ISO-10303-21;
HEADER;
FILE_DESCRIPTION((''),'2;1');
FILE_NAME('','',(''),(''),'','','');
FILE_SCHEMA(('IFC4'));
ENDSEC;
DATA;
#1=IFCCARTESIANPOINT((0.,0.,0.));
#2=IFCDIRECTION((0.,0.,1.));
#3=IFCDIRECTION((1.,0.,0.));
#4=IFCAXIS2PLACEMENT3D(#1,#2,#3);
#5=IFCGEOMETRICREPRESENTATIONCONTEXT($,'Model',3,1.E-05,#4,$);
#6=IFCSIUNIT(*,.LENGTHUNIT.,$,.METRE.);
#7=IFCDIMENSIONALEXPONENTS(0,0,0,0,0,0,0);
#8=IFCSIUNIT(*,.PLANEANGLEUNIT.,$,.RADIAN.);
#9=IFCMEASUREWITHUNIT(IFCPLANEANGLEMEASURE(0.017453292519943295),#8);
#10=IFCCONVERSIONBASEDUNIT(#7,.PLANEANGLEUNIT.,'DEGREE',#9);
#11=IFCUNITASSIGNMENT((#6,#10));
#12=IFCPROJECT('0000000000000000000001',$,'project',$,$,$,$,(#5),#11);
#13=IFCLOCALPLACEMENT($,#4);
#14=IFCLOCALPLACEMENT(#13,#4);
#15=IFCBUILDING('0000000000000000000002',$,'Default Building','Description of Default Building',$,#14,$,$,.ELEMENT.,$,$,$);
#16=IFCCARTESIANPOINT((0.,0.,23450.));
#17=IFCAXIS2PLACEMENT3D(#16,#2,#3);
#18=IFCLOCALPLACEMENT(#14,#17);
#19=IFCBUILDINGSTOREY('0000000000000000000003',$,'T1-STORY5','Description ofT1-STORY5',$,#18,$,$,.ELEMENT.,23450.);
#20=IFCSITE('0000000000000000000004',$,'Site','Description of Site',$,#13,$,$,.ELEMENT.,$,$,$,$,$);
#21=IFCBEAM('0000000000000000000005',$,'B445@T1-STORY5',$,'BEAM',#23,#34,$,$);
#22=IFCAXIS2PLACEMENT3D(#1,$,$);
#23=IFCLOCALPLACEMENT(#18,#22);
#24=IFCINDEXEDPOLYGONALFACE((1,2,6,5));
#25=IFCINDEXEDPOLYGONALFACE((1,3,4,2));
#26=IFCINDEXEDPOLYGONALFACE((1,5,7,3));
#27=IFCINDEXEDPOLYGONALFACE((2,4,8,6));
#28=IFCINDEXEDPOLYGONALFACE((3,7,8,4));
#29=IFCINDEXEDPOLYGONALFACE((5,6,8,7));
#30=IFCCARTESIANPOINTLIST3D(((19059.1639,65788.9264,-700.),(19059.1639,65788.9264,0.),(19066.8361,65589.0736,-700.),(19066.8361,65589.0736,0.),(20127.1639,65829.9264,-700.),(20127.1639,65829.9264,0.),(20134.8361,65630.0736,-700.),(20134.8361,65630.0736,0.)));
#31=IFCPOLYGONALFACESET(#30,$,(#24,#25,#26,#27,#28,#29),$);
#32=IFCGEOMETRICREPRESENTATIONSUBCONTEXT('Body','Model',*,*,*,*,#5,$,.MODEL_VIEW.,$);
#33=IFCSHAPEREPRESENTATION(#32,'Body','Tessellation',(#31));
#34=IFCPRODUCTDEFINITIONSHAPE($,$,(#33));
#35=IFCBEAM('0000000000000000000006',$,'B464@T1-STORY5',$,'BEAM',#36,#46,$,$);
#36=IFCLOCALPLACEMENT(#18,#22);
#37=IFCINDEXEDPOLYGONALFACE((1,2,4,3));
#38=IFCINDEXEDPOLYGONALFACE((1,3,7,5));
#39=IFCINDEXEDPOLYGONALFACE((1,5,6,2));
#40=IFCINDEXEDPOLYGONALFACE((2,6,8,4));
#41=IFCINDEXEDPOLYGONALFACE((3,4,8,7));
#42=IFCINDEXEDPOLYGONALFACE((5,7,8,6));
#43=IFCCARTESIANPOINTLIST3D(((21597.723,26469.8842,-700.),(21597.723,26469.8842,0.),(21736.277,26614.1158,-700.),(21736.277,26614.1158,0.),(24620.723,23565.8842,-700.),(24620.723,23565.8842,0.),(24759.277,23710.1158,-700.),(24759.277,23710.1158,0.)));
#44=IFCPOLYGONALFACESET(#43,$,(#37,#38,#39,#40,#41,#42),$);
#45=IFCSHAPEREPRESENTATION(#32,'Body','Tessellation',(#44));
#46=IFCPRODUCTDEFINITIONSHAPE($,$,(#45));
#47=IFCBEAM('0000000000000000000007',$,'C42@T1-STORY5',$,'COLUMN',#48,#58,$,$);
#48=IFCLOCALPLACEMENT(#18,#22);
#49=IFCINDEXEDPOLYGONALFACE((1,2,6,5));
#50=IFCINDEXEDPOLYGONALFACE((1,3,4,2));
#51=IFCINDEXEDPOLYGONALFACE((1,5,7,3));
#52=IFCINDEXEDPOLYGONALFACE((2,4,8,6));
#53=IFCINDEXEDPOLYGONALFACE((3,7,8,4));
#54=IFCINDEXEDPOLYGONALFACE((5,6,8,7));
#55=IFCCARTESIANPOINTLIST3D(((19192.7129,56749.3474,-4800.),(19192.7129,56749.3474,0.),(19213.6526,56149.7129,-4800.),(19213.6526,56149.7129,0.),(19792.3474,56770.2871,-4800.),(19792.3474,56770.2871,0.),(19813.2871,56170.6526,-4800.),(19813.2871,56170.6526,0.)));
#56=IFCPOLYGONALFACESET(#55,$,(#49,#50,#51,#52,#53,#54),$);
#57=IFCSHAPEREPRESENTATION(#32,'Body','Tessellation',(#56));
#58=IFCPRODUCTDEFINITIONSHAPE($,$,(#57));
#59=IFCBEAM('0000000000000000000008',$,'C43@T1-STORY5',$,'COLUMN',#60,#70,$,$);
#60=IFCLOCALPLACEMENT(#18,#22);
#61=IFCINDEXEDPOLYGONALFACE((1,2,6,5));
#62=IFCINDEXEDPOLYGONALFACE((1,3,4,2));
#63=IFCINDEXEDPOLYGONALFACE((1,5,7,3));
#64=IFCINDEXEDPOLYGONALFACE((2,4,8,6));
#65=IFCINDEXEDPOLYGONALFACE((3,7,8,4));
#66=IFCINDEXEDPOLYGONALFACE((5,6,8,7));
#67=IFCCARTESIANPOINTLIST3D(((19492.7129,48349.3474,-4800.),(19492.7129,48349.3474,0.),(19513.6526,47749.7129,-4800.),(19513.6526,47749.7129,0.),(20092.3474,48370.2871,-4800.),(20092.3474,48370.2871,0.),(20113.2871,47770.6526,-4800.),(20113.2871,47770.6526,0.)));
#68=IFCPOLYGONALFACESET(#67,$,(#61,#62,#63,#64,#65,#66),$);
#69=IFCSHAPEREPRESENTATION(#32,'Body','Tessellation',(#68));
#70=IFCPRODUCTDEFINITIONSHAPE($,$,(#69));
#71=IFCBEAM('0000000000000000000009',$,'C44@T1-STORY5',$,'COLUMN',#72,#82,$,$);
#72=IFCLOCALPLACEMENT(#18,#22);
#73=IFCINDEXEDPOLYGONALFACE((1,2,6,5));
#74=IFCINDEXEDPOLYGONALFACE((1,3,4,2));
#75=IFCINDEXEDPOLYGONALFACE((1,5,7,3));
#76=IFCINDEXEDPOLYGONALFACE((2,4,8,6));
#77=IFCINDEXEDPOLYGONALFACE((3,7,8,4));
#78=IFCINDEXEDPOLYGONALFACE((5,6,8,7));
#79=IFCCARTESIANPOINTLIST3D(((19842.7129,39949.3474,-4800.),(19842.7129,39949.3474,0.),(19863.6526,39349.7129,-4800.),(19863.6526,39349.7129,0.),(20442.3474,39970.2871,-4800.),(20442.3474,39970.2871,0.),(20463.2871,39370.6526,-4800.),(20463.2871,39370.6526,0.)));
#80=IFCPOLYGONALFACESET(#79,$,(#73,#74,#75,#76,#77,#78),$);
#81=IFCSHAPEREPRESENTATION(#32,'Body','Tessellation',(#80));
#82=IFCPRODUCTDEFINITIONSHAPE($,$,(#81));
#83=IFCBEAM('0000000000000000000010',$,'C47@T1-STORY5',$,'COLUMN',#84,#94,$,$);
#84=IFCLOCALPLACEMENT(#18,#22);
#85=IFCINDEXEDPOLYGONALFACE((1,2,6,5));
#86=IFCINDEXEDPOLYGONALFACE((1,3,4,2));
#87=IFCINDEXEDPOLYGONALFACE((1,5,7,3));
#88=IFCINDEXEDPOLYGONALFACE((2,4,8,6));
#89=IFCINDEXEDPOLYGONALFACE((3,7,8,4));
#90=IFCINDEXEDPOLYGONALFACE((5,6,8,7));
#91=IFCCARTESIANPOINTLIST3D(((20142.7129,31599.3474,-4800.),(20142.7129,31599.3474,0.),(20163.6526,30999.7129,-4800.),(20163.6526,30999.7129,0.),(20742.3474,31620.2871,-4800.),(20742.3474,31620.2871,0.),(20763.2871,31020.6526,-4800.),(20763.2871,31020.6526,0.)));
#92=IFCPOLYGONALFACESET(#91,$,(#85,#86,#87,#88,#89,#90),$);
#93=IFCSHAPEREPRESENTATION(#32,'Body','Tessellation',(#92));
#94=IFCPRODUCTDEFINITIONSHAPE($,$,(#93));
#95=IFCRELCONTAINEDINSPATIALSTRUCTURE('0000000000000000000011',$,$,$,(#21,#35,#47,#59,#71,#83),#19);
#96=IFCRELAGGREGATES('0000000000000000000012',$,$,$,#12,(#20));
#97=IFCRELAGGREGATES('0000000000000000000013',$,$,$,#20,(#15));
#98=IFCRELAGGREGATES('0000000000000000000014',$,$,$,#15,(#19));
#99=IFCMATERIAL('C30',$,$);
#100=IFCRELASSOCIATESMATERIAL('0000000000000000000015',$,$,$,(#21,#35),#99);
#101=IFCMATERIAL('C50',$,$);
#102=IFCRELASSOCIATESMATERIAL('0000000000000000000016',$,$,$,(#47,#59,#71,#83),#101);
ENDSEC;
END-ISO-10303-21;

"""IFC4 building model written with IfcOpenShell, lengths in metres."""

from ifc_helpers import new_model, entity, si_unit, converted_unit, frame, origin_with_axes, place, context, subcontext, project, spatial, rectangle, extrude, material, element, save


model = new_model("IFC4")

# Units and contexts
model_context = context("Model", 3, precision=1e-05, world=origin_with_axes())
body_context = subcontext(model_context, "Body", "Model", "MODEL_VIEW")
ifc_project = project(units=[si_unit("LENGTHUNIT", "METRE"), converted_unit("PLANEANGLEUNIT", "DEGREE", entity("IfcPlaneAngleMeasure", 0.017453292519943295), si_unit("PLANEANGLEUNIT", "RADIAN"), dimensions=[0, 0, 0, 0, 0, 0, 0])], contexts=[model_context])

# Site, building, storey
site_placement = place(None, origin_with_axes())
site = spatial("IfcSite", under=ifc_project, at=site_placement, Name="Site", Description="Description of Site", CompositionType="ELEMENT")
building_placement = place(site_placement, origin_with_axes())
building = spatial("IfcBuilding", under=site, at=building_placement, Name="Default Building", Description="Description of Default Building", CompositionType="ELEMENT")
storey_placement = place(building_placement, frame((0.0, 0.0, 23450.0), z_axis=(0.0, 0.0, 1.0), x_axis=(1.0, 0.0, 0.0)))
storey = spatial("IfcBuildingStorey", under=building, at=storey_placement, Name="T1-STORY5", Description="Description ofT1-STORY5", CompositionType="ELEMENT", Elevation=23450.0)

# Beams
ifc_material_1 = material(Name="C30")
beam_1_placement = place(storey_placement, frame((19063.0, 65689.0, -350.0), z_axis=(0.999264, 0.038361, 0.0), x_axis=(-0.038361, 0.999264, 0.0)))
element("IfcBeam", 1, at=beam_1_placement, inside=storey, material=ifc_material_1, Name="B445@T1-STORY5", ObjectType="BEAM", context=body_context, shape_type="SweptSolid", body=[
    extrude(rectangle(XDim=200.0, YDim=700.0), origin_with_axes(), (0.0, 0.0, 1.0), 1068.7867),
])
beam_2_placement = place(storey_placement, frame((21667.0, 26542.0, -350.0), z_axis=(0.721158, -0.69277, 0.0), x_axis=(0.69277, 0.721158, 0.0)))
element("IfcBeam", 2, at=beam_2_placement, inside=storey, material=ifc_material_1, Name="B464@T1-STORY5", ObjectType="BEAM", context=body_context, shape_type="SweptSolid", body=[
    extrude(rectangle(XDim=200.0, YDim=700.0), origin_with_axes(), (0.0, 0.0, 1.0), 4191.8665),
])
ifc_material_2 = material(Name="C50")
for number, where, z_axis, x_axis, name in (
    (3, (19503.0, 56460.0, -4800.0), (0.0, 0.0, 1.0), (-0.999391, -0.034899, 0.0), "C42@T1-STORY5"),
    (4, (19803.0, 48060.0, -4800.0), (0.0, 0.0, 1.0), (-0.999391, -0.034899, 0.0), "C43@T1-STORY5"),
    (5, (20153.0, 39660.0, -4800.0), (0.0, 0.0, 1.0), (-0.999391, -0.034899, 0.0), "C44@T1-STORY5"),
    (6, (20453.0, 31310.0, -4800.0), (0.0, 0.0, 1.0), (-0.999391, -0.034899, 0.0), "C47@T1-STORY5"),
):
    element("IfcBeam", number, at=place(storey_placement, frame(where, z_axis=z_axis, x_axis=x_axis)), inside=storey, material=ifc_material_2, Name=name, ObjectType="COLUMN", context=body_context, shape_type="SweptSolid", body=[
        extrude(rectangle(XDim=600.0, YDim=600.0), origin_with_axes(), (0.0, 0.0, 1.0), 4800.0),
    ])

save(model, "model.ifc")
